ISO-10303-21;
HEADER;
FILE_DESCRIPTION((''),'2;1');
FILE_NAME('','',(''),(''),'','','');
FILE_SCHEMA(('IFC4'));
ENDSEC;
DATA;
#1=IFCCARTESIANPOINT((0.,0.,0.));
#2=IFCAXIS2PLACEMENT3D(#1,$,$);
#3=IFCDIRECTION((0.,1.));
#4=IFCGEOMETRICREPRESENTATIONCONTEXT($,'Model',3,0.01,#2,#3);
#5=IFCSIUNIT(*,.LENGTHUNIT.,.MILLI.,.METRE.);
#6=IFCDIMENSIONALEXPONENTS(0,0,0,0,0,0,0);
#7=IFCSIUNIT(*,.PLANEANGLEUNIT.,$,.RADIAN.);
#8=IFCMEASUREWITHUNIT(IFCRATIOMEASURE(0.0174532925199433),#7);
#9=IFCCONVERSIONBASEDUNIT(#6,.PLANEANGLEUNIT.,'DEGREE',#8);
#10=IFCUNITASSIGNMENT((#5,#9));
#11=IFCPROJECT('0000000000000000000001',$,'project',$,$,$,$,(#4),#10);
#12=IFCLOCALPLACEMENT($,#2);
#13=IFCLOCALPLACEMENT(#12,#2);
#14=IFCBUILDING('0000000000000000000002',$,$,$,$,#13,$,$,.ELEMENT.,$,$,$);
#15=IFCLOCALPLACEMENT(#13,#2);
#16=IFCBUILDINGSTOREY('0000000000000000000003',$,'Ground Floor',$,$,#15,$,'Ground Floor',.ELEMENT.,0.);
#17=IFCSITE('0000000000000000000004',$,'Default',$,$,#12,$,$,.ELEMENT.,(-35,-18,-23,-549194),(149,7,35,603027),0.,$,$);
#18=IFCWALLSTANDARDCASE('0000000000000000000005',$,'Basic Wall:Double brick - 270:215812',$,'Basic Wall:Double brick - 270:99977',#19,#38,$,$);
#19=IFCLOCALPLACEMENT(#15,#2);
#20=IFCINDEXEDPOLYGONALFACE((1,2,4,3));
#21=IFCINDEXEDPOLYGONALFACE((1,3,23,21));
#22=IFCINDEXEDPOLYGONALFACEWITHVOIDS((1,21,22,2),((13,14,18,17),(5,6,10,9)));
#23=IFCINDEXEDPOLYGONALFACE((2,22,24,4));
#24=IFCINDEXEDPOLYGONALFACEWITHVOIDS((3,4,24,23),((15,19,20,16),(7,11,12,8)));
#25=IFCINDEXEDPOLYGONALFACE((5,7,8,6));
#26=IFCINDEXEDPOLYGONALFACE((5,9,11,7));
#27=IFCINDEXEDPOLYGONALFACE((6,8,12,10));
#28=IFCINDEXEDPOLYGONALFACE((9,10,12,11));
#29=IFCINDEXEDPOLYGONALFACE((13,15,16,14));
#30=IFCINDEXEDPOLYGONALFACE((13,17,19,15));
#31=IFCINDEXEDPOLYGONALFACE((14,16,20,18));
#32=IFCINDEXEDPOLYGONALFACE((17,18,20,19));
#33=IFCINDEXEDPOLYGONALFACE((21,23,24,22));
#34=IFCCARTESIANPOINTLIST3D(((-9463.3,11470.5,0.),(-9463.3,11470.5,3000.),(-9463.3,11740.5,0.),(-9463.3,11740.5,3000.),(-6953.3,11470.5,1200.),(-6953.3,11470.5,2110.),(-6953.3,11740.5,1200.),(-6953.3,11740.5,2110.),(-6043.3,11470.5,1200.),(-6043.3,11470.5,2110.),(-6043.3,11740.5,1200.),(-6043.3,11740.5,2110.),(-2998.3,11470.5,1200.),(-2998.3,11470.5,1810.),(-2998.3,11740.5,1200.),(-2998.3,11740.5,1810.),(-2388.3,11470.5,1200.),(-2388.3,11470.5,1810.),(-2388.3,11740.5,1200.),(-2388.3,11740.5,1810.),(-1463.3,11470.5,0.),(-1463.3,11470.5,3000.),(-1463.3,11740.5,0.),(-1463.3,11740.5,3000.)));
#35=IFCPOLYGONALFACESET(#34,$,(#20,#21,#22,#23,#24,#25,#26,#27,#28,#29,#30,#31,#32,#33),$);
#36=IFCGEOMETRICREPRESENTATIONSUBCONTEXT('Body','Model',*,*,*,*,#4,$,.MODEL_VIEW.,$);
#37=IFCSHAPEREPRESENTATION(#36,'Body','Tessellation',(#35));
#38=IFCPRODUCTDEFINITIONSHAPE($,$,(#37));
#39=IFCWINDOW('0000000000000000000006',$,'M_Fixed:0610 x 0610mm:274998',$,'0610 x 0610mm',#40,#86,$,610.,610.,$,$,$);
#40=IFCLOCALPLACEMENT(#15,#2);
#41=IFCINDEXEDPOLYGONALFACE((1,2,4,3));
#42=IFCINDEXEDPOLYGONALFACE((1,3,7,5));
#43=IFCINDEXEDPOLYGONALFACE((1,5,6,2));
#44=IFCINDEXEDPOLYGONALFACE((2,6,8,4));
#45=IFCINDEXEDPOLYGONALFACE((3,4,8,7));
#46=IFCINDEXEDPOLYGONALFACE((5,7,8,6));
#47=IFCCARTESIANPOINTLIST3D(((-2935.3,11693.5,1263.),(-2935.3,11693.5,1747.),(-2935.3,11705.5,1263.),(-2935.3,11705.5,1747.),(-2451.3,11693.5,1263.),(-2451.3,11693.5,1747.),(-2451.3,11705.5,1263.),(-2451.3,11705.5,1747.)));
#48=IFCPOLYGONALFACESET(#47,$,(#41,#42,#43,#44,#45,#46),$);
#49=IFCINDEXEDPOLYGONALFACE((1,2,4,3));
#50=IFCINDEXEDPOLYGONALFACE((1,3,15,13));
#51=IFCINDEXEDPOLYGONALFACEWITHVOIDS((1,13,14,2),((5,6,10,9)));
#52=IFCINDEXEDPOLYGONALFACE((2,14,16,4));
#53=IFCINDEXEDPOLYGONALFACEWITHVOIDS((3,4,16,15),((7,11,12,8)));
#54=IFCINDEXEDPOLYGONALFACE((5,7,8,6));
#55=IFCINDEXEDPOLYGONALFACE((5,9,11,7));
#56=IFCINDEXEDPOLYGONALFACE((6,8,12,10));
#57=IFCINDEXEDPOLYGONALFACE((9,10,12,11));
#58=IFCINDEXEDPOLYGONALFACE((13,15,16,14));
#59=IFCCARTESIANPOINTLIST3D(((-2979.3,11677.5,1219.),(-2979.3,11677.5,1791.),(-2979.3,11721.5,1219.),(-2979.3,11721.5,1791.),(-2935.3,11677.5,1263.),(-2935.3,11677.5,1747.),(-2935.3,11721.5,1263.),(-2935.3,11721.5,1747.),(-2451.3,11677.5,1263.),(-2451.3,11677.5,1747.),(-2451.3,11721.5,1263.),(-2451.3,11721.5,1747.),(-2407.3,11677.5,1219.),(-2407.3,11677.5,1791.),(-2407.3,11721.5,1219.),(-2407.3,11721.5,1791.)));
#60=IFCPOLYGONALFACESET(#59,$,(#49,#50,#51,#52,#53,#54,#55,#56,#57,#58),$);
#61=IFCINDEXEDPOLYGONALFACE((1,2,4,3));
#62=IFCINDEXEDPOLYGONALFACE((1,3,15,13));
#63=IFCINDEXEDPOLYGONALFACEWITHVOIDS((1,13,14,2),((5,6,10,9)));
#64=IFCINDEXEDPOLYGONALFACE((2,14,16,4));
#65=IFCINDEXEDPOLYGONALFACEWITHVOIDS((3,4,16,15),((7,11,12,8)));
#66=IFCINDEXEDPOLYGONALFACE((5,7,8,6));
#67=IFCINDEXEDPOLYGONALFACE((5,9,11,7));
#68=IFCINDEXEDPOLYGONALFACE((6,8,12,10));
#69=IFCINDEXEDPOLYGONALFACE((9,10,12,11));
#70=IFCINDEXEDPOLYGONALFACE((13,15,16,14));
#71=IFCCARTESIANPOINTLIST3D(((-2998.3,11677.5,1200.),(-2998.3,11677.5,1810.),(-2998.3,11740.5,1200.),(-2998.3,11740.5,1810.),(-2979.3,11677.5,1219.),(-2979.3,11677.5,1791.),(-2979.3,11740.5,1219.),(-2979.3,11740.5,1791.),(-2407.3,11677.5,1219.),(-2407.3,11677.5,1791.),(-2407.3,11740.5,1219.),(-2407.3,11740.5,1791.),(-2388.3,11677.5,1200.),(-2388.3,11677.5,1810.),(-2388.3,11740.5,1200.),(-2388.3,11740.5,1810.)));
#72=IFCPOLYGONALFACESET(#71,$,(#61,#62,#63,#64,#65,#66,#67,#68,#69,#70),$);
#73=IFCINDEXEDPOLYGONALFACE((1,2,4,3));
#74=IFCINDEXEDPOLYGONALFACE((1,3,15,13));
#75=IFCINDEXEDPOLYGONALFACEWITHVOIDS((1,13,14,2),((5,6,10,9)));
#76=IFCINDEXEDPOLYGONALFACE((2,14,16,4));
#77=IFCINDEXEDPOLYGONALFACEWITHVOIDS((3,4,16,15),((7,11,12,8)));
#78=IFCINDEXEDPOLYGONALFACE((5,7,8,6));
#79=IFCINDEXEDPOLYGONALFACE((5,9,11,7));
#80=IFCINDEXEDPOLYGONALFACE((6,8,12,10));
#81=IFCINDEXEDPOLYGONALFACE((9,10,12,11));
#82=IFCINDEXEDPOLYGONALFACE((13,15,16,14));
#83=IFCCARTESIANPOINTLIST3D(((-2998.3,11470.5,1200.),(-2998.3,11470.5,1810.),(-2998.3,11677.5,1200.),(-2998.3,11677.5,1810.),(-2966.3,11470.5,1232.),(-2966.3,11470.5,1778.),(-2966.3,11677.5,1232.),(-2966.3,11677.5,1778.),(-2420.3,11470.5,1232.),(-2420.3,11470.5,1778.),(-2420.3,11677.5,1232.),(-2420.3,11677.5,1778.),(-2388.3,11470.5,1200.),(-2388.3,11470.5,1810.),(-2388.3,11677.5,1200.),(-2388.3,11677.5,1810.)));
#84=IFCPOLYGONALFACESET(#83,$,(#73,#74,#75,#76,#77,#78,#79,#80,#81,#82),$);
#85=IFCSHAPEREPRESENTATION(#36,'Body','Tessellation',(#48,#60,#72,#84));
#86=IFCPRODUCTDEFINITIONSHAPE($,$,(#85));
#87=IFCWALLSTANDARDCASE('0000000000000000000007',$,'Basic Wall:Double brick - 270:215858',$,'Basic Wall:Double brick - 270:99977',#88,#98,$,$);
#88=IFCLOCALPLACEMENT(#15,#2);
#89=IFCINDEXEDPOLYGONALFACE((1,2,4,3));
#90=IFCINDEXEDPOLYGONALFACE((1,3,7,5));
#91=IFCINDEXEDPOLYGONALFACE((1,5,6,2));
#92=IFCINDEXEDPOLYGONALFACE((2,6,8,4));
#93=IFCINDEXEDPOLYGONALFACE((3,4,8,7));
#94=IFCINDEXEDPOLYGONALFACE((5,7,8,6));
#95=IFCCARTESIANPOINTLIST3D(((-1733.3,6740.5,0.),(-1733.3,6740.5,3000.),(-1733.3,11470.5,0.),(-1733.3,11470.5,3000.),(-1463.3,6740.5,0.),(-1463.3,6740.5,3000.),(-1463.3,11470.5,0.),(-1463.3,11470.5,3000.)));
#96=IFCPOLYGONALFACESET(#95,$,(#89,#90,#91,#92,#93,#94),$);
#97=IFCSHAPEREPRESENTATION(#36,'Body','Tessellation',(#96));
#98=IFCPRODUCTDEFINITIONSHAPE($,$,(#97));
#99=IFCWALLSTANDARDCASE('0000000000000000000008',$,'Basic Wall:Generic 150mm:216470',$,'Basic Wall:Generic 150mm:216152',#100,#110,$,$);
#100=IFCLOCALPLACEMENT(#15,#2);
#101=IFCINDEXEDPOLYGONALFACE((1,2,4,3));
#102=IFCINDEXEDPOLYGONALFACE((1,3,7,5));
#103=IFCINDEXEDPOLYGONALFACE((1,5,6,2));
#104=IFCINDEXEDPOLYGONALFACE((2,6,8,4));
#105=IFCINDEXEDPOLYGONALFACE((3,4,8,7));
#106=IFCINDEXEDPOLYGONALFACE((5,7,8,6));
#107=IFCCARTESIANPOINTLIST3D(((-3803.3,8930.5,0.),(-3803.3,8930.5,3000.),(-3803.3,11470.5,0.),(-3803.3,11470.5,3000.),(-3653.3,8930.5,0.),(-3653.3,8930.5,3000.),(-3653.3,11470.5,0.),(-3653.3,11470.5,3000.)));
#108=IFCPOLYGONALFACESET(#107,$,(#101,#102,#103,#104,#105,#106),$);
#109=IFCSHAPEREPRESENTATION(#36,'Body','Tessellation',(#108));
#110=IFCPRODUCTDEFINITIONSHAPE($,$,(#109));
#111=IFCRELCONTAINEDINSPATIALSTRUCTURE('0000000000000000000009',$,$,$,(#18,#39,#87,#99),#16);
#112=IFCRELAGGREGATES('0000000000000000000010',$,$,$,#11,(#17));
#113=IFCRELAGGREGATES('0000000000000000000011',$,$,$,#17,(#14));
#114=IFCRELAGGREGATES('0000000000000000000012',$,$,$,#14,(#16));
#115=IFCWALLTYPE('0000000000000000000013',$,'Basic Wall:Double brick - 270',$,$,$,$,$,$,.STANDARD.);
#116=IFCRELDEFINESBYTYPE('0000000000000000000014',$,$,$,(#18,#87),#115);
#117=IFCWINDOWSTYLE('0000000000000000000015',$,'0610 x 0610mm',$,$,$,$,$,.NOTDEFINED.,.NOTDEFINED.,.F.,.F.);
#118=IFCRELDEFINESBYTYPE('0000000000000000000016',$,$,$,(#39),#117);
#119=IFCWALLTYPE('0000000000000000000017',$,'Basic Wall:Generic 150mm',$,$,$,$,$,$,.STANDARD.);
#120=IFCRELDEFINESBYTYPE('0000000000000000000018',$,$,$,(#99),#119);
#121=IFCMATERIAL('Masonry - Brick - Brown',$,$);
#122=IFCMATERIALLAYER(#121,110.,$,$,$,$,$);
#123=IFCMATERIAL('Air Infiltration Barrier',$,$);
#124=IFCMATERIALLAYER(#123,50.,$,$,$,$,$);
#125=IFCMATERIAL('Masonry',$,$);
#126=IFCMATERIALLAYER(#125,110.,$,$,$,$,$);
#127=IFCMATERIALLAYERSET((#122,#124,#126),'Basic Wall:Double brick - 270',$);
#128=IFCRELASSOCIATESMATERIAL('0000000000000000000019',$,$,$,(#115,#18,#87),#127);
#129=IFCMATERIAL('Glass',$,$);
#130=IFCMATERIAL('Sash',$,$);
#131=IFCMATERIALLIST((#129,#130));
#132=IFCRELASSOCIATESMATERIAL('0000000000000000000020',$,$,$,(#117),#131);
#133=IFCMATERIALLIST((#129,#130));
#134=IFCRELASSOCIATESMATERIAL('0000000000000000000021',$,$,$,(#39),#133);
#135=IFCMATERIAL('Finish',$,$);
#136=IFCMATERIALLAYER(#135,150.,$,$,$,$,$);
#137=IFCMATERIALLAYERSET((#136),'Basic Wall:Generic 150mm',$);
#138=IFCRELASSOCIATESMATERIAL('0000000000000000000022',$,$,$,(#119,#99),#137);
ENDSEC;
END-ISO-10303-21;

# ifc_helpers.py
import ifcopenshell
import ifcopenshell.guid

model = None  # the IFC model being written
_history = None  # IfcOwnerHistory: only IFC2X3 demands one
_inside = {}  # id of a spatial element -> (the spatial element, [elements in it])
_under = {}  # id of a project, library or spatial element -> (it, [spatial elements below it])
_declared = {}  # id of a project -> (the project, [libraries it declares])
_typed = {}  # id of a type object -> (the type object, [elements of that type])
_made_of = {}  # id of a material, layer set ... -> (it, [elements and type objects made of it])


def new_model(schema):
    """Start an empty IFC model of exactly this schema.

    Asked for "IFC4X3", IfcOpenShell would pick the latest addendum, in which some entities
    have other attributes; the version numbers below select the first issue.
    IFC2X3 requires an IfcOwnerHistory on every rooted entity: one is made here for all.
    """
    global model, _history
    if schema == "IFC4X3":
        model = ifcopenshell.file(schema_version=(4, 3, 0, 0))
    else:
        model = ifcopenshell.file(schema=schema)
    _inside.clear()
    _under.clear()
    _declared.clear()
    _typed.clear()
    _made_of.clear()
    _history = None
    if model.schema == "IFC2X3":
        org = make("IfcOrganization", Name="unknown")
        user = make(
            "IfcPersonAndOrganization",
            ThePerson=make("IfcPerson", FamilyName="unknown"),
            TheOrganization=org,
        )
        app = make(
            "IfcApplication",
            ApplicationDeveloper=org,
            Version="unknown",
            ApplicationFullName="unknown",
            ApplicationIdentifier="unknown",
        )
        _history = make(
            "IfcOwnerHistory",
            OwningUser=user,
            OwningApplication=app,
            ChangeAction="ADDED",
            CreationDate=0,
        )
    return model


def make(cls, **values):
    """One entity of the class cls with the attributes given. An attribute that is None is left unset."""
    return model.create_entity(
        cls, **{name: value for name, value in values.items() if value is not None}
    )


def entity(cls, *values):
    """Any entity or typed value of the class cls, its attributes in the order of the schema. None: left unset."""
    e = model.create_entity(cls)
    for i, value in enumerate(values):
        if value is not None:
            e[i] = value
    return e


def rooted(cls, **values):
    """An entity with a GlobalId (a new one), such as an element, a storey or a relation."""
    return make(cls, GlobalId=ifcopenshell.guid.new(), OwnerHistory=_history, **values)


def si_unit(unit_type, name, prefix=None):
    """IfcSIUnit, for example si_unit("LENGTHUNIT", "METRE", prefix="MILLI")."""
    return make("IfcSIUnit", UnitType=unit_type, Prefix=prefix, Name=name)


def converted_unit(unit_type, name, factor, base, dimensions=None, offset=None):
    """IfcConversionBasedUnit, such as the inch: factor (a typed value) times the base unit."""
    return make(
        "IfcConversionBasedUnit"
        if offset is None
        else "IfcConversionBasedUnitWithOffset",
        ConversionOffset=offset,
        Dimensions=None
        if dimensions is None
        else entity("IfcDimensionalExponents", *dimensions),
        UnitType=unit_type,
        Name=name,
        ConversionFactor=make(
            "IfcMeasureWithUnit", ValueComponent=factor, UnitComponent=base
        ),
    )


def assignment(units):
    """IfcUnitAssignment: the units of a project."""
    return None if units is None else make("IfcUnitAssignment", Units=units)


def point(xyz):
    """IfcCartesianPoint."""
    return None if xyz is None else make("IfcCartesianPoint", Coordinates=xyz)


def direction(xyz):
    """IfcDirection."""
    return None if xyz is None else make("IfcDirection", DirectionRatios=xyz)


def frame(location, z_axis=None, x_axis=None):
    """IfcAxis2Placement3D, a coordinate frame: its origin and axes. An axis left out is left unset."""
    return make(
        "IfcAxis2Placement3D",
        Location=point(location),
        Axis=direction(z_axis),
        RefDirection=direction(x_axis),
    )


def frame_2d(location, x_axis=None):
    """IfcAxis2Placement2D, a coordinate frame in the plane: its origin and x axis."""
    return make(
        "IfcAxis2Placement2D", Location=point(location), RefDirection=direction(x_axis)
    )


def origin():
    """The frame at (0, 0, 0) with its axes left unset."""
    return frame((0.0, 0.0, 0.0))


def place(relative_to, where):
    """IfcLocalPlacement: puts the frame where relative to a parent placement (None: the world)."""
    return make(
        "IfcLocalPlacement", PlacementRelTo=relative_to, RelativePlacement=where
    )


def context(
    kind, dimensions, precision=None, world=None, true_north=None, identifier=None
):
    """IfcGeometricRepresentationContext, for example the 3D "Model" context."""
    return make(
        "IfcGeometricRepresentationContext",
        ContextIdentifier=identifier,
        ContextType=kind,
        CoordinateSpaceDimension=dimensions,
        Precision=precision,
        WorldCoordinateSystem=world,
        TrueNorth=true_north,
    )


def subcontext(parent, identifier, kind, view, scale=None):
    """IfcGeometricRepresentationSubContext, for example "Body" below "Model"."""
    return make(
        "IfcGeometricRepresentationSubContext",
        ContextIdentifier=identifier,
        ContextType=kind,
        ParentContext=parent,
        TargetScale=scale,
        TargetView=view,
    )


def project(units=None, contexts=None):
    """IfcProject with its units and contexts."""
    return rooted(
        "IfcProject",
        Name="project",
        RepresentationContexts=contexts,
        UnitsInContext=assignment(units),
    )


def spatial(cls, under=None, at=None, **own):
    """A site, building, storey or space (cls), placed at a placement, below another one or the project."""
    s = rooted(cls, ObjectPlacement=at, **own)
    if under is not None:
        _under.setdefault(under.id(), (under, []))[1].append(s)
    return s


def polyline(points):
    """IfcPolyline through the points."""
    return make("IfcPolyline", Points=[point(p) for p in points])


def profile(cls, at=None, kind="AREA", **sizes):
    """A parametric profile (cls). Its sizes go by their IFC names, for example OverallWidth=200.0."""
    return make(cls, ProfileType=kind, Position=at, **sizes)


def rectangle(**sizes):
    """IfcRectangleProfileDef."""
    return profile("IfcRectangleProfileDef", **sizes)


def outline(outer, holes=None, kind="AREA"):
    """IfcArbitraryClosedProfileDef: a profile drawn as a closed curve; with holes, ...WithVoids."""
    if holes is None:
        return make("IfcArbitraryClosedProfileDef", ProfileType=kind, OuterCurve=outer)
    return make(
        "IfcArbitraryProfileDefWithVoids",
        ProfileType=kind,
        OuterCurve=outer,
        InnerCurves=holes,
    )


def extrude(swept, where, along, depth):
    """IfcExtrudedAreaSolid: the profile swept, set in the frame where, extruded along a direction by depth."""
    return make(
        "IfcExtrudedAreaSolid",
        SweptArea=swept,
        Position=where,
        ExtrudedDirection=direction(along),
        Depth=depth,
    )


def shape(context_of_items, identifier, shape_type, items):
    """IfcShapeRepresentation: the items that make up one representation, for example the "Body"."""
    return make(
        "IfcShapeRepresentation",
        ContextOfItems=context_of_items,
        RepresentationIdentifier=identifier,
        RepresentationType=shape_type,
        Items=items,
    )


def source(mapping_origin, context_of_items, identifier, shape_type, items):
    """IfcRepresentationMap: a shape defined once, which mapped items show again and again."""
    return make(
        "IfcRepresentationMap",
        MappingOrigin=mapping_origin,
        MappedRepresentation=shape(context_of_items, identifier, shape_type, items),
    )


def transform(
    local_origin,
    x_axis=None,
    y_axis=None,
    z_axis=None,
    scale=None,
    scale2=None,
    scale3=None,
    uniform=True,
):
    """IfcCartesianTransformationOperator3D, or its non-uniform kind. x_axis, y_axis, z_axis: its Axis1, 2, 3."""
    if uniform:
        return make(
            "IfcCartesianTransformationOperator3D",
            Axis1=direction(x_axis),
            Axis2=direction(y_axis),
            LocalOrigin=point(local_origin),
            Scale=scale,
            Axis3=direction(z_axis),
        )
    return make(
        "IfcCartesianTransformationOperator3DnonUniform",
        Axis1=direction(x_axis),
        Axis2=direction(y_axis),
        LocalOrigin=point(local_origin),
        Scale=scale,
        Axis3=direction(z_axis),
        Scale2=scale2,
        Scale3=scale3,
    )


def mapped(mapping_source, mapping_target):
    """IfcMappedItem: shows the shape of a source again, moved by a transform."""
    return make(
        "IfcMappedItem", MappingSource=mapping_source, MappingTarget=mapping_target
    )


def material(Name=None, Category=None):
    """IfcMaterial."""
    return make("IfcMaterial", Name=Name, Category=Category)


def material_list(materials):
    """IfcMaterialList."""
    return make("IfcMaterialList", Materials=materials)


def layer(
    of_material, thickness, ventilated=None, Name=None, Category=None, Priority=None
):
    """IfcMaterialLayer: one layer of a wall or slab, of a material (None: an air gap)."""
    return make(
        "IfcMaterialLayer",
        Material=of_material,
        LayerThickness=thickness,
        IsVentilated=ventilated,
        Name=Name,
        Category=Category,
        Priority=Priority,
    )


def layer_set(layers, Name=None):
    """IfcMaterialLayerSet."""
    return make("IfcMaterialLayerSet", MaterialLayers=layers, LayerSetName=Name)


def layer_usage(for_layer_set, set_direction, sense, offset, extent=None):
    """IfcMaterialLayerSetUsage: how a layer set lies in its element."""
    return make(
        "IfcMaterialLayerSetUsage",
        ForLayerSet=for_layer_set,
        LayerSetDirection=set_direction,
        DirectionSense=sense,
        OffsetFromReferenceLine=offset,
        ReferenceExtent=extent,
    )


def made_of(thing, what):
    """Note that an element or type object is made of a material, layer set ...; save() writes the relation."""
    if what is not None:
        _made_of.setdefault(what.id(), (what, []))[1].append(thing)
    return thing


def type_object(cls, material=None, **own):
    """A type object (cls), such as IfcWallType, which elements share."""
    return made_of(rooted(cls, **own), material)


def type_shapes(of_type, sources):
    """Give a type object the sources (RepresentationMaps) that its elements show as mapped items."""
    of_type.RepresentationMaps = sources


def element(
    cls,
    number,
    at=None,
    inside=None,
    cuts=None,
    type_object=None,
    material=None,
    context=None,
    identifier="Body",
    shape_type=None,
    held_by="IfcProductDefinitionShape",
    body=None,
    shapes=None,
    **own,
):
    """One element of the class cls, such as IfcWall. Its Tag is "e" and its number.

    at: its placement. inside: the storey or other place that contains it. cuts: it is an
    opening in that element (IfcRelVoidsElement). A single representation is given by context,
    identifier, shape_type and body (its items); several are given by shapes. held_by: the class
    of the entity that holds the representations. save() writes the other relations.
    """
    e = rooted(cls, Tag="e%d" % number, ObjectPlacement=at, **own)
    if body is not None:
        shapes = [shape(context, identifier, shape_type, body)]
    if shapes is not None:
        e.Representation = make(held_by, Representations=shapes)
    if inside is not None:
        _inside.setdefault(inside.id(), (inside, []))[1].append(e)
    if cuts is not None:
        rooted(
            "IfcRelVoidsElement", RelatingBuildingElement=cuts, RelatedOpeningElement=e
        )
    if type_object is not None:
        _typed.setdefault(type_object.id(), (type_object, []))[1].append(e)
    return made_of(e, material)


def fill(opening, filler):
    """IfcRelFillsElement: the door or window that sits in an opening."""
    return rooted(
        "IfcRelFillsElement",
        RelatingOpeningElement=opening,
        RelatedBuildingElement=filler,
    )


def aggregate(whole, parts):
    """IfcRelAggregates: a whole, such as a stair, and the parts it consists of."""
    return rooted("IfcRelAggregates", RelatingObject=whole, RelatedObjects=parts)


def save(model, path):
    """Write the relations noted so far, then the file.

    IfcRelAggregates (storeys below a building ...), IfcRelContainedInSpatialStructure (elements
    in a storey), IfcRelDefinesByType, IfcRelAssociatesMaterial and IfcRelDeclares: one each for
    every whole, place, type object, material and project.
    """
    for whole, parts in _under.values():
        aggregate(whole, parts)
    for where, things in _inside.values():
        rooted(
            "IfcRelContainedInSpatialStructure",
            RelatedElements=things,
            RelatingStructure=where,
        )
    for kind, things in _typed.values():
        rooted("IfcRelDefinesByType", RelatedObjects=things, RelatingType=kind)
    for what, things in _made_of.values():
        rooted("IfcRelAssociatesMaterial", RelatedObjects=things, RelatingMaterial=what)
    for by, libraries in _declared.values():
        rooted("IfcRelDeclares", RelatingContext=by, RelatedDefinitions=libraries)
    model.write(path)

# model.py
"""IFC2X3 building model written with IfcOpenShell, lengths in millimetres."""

from ifc_helpers import new_model, entity, si_unit, converted_unit, direction, frame, frame_2d, origin, place, context, subcontext, project, spatial, polyline, rectangle, outline, extrude, source, transform, mapped, material, material_list, layer, layer_set, layer_usage, type_object, type_shapes, element, fill, save


model = new_model("IFC2X3")

# Units and contexts
model_context = context("Model", 3, precision=0.01, world=origin(), true_north=direction((0.0, 1.0)))
body_context = subcontext(model_context, "Body", "Model", "MODEL_VIEW")
ifc_project = project(units=[si_unit("LENGTHUNIT", "METRE", prefix="MILLI"), converted_unit("PLANEANGLEUNIT", "DEGREE", entity("IfcRatioMeasure", 0.0174532925199433), si_unit("PLANEANGLEUNIT", "RADIAN"), dimensions=[0, 0, 0, 0, 0, 0, 0])], contexts=[model_context])

# Site, building, storey
site_placement = place(None, origin())
site = spatial("IfcSite", under=ifc_project, at=site_placement, Name="Default", CompositionType="ELEMENT", RefLatitude=(-35, -18, -23, -549194), RefLongitude=(149, 7, 35, 603027), RefElevation=0.0)
building_placement = place(site_placement, origin())
building = spatial("IfcBuilding", under=site, at=building_placement, CompositionType="ELEMENT")
storey_placement = place(building_placement, origin())
storey = spatial("IfcBuildingStorey", under=building, at=storey_placement, Name="Ground Floor", LongName="Ground Floor", CompositionType="ELEMENT", Elevation=0.0)

# Wall, openings, window
ifc_material_1 = material(Name="Masonry - Brick - Brown")
ifc_layer_1 = layer(ifc_material_1, 110.0)
ifc_material_2 = material(Name="Air Infiltration Barrier")
ifc_layer_2 = layer(ifc_material_2, 50.0)
ifc_material_3 = material(Name="Masonry")
ifc_layer_3 = layer(ifc_material_3, 110.0)
ifc_layer_set_1 = layer_set([ifc_layer_1, ifc_layer_2, ifc_layer_3], Name="Basic Wall:Double brick - 270")
ifc_layer_usage_1 = layer_usage(ifc_layer_set_1, "AXIS2", "NEGATIVE", 135.0)
wall_type_1 = type_object("IfcWallType", Name="Basic Wall:Double brick - 270", PredefinedType="STANDARD", material=ifc_layer_set_1)
wall_1_placement = place(storey_placement, frame((-9463.3, 11605.5, 0.0)))
wall_1 = element("IfcWallStandardCase", 1, at=wall_1_placement, inside=storey, type_object=wall_type_1, material=ifc_layer_usage_1, Name="Basic Wall:Double brick - 270:215812", ObjectType="Basic Wall:Double brick - 270:99977", context=body_context, shape_type="SweptSolid", body=[
    extrude(rectangle(XDim=8000.0, YDim=270.0, at=frame_2d((4000.0, 0.0), x_axis=(-1.0, 0.0))), origin(), (0.0, 0.0, 1.0), 3000.0),
])
opening_1_placement = place(wall_1_placement, frame((6465.0, -135.0, 1200.0)))
opening_1 = element("IfcOpeningElement", 2, at=opening_1_placement, cuts=wall_1, ObjectType="Opening", context=body_context, shape_type="SweptSolid", body=[
    extrude(rectangle(XDim=610.0, YDim=610.0, at=frame_2d((305.0, 305.0), x_axis=(1.0, 0.0))), frame((0.0, 0.0, 0.0), z_axis=(0.0, 1.0, 0.0), x_axis=(0.0, 0.0, 1.0)), (0.0, 0.0, 1.0), 270.0),
])
opening_2_placement = place(wall_1_placement, frame((2510.0, -135.0, 1200.0)))
element("IfcOpeningElement", 3, at=opening_2_placement, cuts=wall_1, ObjectType="Opening", context=body_context, shape_type="SweptSolid", body=[
    extrude(rectangle(XDim=910.0, YDim=910.0, at=frame_2d((455.0, 455.0), x_axis=(-1.0, 0.0))), frame((0.0, 0.0, 0.0), z_axis=(0.0, 1.0, 0.0), x_axis=(0.0, 0.0, 1.0)), (0.0, 0.0, 1.0), 270.0),
])
ifc_material_4 = material(Name="Glass")
ifc_material_5 = material(Name="Sash")
ifc_material_list_1 = material_list([ifc_material_4, ifc_material_5])
ifc_material_list_2 = material_list([ifc_material_4, ifc_material_5])
window_style = type_object("IfcWindowStyle", Name="0610 x 0610mm", ConstructionType="NOTDEFINED", OperationType="NOTDEFINED", ParameterTakesPrecedence=False, Sizeable=False, material=ifc_material_list_2)
shared_shape = source(origin(), body_context, "Body", "SweptSolid", [
    extrude(rectangle(XDim=12.0, YDim=484.0, at=frame_2d((0.0, 0.0), x_axis=(1.0, 0.0))), frame((305.0, 229.0, 63.0), z_axis=(0.0, 0.0, 1.0), x_axis=(0.0, -1.0, 0.0)), (0.0, 0.0, 1.0), 484.0),
    extrude(outline(polyline([(-286.0, -286.0), (286.0, -286.0), (286.0, 286.0), (-286.0, 286.0), (-286.0, -286.0)]), holes=[polyline([(-242.0, -242.0), (-242.0, 242.0), (242.0, 242.0), (242.0, -242.0), (-242.0, -242.0)])]), frame((305.0, 207.0, 305.0), z_axis=(0.0, 1.0, 0.0), x_axis=(1.0, 0.0, 0.0)), (0.0, 0.0, 1.0), 44.0),
    extrude(outline(polyline([(-305.0, -305.0), (305.0, -305.0), (305.0, 305.0), (-305.0, 305.0), (-305.0, -305.0)]), holes=[polyline([(-286.0, -286.0), (-286.0, 286.0), (286.0, 286.0), (286.0, -286.0), (-286.0, -286.0)])]), frame((305.0, 207.0, 305.0), z_axis=(0.0, 1.0, 0.0), x_axis=(1.0, 0.0, 0.0)), (0.0, 0.0, 1.0), 63.0),
    extrude(outline(polyline([(-305.0, -305.0), (305.0, -305.0), (305.0, 305.0), (-305.0, 305.0), (-305.0, -305.0)]), holes=[polyline([(-273.0, -273.0), (-273.0, 273.0), (273.0, 273.0), (273.0, -273.0), (-273.0, -273.0)])]), frame((305.0, 0.0, 305.0), z_axis=(0.0, 1.0, 0.0), x_axis=(1.0, 0.0, 0.0)), (0.0, 0.0, 1.0), 207.0),
])
type_shapes(window_style, [shared_shape])
window_placement = place(opening_1_placement, origin())
window = element("IfcWindow", 4, at=window_placement, inside=storey, type_object=window_style, material=ifc_material_list_1, Name="M_Fixed:0610 x 0610mm:274998", ObjectType="0610 x 0610mm", OverallHeight=610.0, OverallWidth=610.0, context=body_context, shape_type="MappedRepresentation", body=[
    mapped(shared_shape, transform((0.0, 0.0, 0.0), scale=1.0)),
])
fill(opening_1, window)

# Walls
ifc_layer_usage_2 = layer_usage(ifc_layer_set_1, "AXIS2", "NEGATIVE", 135.0)
wall_2_placement = place(storey_placement, frame((-1598.3, 11470.5, 0.0), z_axis=(0.0, 0.0, 1.0), x_axis=(0.0, -1.0, 0.0)))
element("IfcWallStandardCase", 5, at=wall_2_placement, inside=storey, type_object=wall_type_1, material=ifc_layer_usage_2, Name="Basic Wall:Double brick - 270:215858", ObjectType="Basic Wall:Double brick - 270:99977", context=body_context, shape_type="SweptSolid", body=[
    extrude(rectangle(XDim=4730.0, YDim=270.0, at=frame_2d((2365.0, 0.0), x_axis=(-1.0, 0.0))), origin(), (0.0, 0.0, 1.0), 3000.0),
])
ifc_material_6 = material(Name="Finish")
ifc_layer_4 = layer(ifc_material_6, 150.0)
ifc_layer_set_2 = layer_set([ifc_layer_4], Name="Basic Wall:Generic 150mm")
ifc_layer_usage_3 = layer_usage(ifc_layer_set_2, "AXIS2", "NEGATIVE", 75.0)
wall_type_2 = type_object("IfcWallType", Name="Basic Wall:Generic 150mm", PredefinedType="STANDARD", material=ifc_layer_set_2)
wall_3_placement = place(storey_placement, frame((-3728.3, 8930.5, 0.0), z_axis=(0.0, 0.0, 1.0), x_axis=(0.0, 1.0, 0.0)))
element("IfcWallStandardCase", 6, at=wall_3_placement, inside=storey, type_object=wall_type_2, material=ifc_layer_usage_3, Name="Basic Wall:Generic 150mm:216470", ObjectType="Basic Wall:Generic 150mm:216152", context=body_context, shape_type="SweptSolid", body=[
    extrude(rectangle(XDim=2540.0, YDim=150.0, at=frame_2d((1270.0, 0.0), x_axis=(-1.0, 0.0))), origin(), (0.0, 0.0, 1.0), 3000.0),
])

save(model, "model.ifc")
